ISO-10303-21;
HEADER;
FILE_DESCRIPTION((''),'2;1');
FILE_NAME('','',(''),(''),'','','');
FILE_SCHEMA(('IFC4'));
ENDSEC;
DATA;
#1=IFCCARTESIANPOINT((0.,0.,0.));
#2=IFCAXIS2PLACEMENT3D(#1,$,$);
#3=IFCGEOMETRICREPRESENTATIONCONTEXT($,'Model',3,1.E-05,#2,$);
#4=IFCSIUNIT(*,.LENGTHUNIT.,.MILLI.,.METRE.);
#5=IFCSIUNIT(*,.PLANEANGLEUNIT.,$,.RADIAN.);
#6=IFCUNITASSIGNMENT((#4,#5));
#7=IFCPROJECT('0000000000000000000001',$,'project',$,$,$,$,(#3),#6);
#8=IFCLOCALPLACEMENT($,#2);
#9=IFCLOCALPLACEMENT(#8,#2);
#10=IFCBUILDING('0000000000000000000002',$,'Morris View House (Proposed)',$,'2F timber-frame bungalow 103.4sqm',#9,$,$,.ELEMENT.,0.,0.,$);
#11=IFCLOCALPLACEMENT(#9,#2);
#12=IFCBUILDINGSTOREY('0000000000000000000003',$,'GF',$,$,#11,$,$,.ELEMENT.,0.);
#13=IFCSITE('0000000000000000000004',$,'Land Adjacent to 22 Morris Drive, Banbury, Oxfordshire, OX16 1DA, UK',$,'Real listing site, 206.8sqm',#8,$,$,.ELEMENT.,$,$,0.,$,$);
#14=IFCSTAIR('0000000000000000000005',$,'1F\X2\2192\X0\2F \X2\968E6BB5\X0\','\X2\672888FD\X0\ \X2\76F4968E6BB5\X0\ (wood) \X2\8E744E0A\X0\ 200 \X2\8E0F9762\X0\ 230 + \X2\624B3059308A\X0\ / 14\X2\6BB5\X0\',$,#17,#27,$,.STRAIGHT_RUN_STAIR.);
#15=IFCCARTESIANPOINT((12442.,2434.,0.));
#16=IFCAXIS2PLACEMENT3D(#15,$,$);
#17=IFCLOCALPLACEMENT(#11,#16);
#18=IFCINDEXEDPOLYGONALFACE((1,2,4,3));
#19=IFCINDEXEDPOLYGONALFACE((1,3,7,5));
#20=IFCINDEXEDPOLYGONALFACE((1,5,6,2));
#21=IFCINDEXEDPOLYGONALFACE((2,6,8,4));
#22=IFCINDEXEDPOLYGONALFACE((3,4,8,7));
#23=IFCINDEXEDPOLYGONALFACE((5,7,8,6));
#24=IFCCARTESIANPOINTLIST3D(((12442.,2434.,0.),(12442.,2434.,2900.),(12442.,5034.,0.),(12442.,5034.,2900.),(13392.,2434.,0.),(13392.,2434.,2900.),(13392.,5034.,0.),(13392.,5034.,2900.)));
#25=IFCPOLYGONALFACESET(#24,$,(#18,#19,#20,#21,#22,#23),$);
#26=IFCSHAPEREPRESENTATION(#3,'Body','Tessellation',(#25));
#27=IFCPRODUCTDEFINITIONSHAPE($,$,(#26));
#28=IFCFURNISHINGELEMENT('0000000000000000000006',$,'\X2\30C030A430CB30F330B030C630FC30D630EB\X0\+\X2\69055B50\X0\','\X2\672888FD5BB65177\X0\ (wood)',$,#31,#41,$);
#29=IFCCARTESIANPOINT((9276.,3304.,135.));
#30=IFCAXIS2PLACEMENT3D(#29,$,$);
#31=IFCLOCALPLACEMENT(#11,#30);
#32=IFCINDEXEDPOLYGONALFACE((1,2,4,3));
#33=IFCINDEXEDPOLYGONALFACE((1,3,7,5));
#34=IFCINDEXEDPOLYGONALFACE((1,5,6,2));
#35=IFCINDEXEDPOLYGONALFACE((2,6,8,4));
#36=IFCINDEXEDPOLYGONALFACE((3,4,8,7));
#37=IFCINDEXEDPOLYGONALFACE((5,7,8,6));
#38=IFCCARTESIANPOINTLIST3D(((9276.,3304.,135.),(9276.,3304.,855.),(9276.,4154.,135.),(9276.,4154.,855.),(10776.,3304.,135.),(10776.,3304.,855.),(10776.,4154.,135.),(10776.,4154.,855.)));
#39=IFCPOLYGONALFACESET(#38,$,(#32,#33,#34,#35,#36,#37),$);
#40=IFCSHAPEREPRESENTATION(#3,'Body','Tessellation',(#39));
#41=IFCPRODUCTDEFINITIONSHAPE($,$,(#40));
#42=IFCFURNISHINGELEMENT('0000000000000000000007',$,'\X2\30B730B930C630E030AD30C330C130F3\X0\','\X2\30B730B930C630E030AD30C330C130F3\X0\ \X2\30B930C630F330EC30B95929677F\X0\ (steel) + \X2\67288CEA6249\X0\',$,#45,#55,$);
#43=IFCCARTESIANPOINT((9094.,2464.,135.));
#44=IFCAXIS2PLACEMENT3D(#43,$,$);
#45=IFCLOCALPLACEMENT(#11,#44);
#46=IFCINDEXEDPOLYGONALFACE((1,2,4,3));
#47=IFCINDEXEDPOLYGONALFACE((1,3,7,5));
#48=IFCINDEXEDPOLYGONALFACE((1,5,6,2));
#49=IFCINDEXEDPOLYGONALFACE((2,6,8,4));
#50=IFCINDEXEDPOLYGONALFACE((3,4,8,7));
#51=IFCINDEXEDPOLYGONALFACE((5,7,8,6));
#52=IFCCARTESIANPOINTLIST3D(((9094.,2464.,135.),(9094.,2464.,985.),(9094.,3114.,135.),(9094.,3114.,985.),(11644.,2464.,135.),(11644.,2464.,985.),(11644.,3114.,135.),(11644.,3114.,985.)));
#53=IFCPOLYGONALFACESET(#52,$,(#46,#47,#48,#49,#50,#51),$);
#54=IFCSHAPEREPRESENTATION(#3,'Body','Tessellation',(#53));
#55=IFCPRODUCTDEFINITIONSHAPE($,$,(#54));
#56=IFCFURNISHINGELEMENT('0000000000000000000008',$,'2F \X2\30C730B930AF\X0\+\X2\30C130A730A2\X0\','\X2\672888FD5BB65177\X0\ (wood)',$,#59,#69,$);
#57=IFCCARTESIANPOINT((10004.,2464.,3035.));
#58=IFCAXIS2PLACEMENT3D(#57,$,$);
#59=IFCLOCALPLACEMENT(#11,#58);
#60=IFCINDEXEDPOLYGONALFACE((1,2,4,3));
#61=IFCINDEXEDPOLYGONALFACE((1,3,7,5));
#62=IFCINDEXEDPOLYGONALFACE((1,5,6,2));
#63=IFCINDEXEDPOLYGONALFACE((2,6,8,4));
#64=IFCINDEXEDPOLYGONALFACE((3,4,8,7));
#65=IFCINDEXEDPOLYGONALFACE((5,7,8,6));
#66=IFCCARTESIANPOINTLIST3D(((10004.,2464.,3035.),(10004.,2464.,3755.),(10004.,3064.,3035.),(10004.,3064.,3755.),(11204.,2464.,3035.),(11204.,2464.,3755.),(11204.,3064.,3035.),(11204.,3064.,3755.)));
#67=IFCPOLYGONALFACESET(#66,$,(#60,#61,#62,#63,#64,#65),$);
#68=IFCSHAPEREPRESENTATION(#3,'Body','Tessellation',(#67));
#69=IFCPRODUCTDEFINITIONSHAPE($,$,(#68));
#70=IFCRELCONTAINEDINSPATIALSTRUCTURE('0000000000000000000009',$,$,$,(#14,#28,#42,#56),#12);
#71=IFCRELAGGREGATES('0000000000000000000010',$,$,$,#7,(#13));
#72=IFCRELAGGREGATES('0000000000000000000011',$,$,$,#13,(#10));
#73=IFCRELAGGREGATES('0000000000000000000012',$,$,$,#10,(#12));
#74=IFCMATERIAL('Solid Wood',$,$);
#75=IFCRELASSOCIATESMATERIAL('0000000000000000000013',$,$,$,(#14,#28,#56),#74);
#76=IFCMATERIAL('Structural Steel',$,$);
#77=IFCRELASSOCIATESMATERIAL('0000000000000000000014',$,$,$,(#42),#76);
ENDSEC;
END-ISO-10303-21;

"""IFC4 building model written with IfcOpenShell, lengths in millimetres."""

from ifc_helpers import new_model, si_unit, frame, frame_2d, origin, place, context, project, spatial, rectangle, extrude, material, element, save


model = new_model("IFC4")

# Units and contexts
model_context = context("Model", 3, precision=1e-05, world=origin())
ifc_project = project(units=[si_unit("LENGTHUNIT", "METRE", prefix="MILLI"), si_unit("PLANEANGLEUNIT", "RADIAN")], contexts=[model_context])

# Site, building, storey
site_placement = place(None, origin())
site = spatial("IfcSite", under=ifc_project, at=site_placement, Name="Land Adjacent to 22 Morris Drive, Banbury, Oxfordshire, OX16 1DA, UK", ObjectType="Real listing site, 206.8sqm", CompositionType="ELEMENT", RefElevation=0.0)
building_placement = place(site_placement, origin())
building = spatial("IfcBuilding", under=site, at=building_placement, Name="Morris View House (Proposed)", ObjectType="2F timber-frame bungalow 103.4sqm", CompositionType="ELEMENT", ElevationOfRefHeight=0.0, ElevationOfTerrain=0.0)
storey_placement = place(building_placement, origin())
storey = spatial("IfcBuildingStorey", under=building, at=storey_placement, Name="GF", CompositionType="ELEMENT", Elevation=0.0)

# Shared definitions
ifc_material_1 = material(Name="Solid Wood")

# Stair
stair_placement = place(storey_placement, frame((12442.0, 2434.0, 0.0)))
element("IfcStair", 1, at=stair_placement, inside=storey, material=ifc_material_1, Name="1F→2F 階段", Description="木製 直階段 (wood) 蹴上 200 踏面 230 + 手すり / 14段", PredefinedType="STRAIGHT_RUN_STAIR", context=model_context, shape_type="SweptSolid", body=[
    extrude(rectangle(XDim=950.0, YDim=2600.0, at=frame_2d((475.0, 1300.0))), frame((12442.0, 2434.0, 0.0)), (0.0, 0.0, 1.0), 2900.0),
])

# Furnishing elements
furnishing_1_placement = place(storey_placement, frame((9276.0, 3304.0, 135.0)))
element("IfcFurnishingElement", 2, at=furnishing_1_placement, inside=storey, material=ifc_material_1, Name="ダイニングテーブル+椅子", Description="木製家具 (wood)", context=model_context, shape_type="SweptSolid", body=[
    extrude(rectangle(XDim=1500.0, YDim=850.0, at=frame_2d((750.0, 425.0))), frame((9276.0, 3304.0, 135.0)), (0.0, 0.0, 1.0), 720.0),
])
ifc_material_2 = material(Name="Structural Steel")
furnishing_2_placement = place(storey_placement, frame((9094.0, 2464.0, 135.0)))
element("IfcFurnishingElement", 3, at=furnishing_2_placement, inside=storey, material=ifc_material_2, Name="システムキッチン", Description="システムキッチン ステンレス天板 (steel) + 木質扉", context=model_context, shape_type="SweptSolid", body=[
    extrude(rectangle(XDim=2550.0, YDim=650.0, at=frame_2d((1275.0, 325.0))), frame((9094.0, 2464.0, 135.0)), (0.0, 0.0, 1.0), 850.0),
])
furnishing_3_placement = place(storey_placement, frame((10004.0, 2464.0, 3035.0)))
element("IfcFurnishingElement", 4, at=furnishing_3_placement, inside=storey, material=ifc_material_1, Name="2F デスク+チェア", Description="木製家具 (wood)", context=model_context, shape_type="SweptSolid", body=[
    extrude(rectangle(XDim=1200.0, YDim=600.0, at=frame_2d((600.0, 300.0))), frame((10004.0, 2464.0, 3035.0)), (0.0, 0.0, 1.0), 720.0),
])

save(model, "model.ifc")
